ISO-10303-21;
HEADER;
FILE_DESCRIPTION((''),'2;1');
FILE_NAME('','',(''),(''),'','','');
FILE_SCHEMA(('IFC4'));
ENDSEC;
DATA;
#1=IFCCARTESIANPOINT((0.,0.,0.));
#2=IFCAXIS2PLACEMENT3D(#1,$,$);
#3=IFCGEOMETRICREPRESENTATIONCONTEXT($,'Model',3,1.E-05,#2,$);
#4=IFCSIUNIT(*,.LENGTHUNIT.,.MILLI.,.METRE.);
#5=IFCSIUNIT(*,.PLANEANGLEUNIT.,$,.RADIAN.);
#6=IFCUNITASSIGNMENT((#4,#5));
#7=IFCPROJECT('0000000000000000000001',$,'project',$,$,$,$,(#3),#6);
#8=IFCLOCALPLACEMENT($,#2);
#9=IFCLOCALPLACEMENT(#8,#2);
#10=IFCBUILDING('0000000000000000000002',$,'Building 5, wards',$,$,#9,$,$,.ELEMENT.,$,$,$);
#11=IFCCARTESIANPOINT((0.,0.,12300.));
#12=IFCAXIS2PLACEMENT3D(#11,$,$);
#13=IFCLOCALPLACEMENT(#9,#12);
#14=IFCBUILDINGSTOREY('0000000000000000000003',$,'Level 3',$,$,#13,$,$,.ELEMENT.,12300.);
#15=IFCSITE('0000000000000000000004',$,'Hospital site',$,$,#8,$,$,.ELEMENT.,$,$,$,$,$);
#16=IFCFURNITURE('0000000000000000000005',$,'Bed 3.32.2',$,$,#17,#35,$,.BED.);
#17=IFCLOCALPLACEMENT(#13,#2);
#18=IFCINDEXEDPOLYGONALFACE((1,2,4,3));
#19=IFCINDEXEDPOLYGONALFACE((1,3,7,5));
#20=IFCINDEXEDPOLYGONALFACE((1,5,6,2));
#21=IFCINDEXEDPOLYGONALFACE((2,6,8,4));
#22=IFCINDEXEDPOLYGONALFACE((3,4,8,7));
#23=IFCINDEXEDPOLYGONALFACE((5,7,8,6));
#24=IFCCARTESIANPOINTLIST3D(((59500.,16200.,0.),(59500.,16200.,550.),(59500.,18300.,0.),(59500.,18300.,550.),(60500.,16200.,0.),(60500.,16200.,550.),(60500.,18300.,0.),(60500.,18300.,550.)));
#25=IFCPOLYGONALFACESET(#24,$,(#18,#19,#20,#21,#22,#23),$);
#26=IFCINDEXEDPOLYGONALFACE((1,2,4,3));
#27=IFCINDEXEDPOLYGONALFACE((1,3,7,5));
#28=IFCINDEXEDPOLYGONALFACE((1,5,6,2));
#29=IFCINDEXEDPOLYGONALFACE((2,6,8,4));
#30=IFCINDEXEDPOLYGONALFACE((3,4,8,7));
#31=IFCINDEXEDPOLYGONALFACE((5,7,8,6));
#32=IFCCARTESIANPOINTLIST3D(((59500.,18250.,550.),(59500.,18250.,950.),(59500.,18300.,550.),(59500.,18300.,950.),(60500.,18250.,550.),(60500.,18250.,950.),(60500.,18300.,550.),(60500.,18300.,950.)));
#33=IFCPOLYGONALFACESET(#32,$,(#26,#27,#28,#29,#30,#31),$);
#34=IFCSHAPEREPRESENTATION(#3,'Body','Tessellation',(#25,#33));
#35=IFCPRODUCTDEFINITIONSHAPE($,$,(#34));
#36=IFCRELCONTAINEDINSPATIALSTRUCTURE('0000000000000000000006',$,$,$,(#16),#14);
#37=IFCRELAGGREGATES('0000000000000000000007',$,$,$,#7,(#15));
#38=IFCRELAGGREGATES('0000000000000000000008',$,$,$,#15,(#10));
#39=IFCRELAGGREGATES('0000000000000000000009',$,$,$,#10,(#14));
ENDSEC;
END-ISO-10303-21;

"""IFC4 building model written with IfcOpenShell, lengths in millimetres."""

from ifc_helpers import new_model, si_unit, frame, frame_2d, origin, place, context, project, spatial, rectangle, extrude, element, save


model = new_model("IFC4")

# Units and contexts
model_context = context("Model", 3, precision=1e-05, world=origin())
ifc_project = project(units=[si_unit("LENGTHUNIT", "METRE", prefix="MILLI"), si_unit("PLANEANGLEUNIT", "RADIAN")], contexts=[model_context])

# Site, building, storey
site_placement = place(None, origin())
site = spatial("IfcSite", under=ifc_project, at=site_placement, Name="Hospital site", CompositionType="ELEMENT")
building_placement = place(site_placement, origin())
building = spatial("IfcBuilding", under=site, at=building_placement, Name="Building 5, wards", CompositionType="ELEMENT")
storey_placement = place(building_placement, frame((0.0, 0.0, 12300.0)))
storey = spatial("IfcBuildingStorey", under=building, at=storey_placement, Name="Level 3", CompositionType="ELEMENT", Elevation=12300.0)

# Furniture
furniture_placement = place(storey_placement, frame((59500.0, 16200.0, 0.0)))
element("IfcFurniture", 1, at=furniture_placement, inside=storey, Name="Bed 3.32.2", PredefinedType="BED", context=model_context, shape_type="SweptSolid", body=[
    extrude(rectangle(XDim=1000.0, YDim=2100.0, at=frame_2d((500.0, 1050.0))), origin(), (0.0, 0.0, 1.0), 550.0),
    extrude(rectangle(XDim=1000.0, YDim=50.0, at=frame_2d((500.0, 2075.0))), frame((0.0, 0.0, 550.0)), (0.0, 0.0, 1.0), 400.0),
])

save(model, "model.ifc")
